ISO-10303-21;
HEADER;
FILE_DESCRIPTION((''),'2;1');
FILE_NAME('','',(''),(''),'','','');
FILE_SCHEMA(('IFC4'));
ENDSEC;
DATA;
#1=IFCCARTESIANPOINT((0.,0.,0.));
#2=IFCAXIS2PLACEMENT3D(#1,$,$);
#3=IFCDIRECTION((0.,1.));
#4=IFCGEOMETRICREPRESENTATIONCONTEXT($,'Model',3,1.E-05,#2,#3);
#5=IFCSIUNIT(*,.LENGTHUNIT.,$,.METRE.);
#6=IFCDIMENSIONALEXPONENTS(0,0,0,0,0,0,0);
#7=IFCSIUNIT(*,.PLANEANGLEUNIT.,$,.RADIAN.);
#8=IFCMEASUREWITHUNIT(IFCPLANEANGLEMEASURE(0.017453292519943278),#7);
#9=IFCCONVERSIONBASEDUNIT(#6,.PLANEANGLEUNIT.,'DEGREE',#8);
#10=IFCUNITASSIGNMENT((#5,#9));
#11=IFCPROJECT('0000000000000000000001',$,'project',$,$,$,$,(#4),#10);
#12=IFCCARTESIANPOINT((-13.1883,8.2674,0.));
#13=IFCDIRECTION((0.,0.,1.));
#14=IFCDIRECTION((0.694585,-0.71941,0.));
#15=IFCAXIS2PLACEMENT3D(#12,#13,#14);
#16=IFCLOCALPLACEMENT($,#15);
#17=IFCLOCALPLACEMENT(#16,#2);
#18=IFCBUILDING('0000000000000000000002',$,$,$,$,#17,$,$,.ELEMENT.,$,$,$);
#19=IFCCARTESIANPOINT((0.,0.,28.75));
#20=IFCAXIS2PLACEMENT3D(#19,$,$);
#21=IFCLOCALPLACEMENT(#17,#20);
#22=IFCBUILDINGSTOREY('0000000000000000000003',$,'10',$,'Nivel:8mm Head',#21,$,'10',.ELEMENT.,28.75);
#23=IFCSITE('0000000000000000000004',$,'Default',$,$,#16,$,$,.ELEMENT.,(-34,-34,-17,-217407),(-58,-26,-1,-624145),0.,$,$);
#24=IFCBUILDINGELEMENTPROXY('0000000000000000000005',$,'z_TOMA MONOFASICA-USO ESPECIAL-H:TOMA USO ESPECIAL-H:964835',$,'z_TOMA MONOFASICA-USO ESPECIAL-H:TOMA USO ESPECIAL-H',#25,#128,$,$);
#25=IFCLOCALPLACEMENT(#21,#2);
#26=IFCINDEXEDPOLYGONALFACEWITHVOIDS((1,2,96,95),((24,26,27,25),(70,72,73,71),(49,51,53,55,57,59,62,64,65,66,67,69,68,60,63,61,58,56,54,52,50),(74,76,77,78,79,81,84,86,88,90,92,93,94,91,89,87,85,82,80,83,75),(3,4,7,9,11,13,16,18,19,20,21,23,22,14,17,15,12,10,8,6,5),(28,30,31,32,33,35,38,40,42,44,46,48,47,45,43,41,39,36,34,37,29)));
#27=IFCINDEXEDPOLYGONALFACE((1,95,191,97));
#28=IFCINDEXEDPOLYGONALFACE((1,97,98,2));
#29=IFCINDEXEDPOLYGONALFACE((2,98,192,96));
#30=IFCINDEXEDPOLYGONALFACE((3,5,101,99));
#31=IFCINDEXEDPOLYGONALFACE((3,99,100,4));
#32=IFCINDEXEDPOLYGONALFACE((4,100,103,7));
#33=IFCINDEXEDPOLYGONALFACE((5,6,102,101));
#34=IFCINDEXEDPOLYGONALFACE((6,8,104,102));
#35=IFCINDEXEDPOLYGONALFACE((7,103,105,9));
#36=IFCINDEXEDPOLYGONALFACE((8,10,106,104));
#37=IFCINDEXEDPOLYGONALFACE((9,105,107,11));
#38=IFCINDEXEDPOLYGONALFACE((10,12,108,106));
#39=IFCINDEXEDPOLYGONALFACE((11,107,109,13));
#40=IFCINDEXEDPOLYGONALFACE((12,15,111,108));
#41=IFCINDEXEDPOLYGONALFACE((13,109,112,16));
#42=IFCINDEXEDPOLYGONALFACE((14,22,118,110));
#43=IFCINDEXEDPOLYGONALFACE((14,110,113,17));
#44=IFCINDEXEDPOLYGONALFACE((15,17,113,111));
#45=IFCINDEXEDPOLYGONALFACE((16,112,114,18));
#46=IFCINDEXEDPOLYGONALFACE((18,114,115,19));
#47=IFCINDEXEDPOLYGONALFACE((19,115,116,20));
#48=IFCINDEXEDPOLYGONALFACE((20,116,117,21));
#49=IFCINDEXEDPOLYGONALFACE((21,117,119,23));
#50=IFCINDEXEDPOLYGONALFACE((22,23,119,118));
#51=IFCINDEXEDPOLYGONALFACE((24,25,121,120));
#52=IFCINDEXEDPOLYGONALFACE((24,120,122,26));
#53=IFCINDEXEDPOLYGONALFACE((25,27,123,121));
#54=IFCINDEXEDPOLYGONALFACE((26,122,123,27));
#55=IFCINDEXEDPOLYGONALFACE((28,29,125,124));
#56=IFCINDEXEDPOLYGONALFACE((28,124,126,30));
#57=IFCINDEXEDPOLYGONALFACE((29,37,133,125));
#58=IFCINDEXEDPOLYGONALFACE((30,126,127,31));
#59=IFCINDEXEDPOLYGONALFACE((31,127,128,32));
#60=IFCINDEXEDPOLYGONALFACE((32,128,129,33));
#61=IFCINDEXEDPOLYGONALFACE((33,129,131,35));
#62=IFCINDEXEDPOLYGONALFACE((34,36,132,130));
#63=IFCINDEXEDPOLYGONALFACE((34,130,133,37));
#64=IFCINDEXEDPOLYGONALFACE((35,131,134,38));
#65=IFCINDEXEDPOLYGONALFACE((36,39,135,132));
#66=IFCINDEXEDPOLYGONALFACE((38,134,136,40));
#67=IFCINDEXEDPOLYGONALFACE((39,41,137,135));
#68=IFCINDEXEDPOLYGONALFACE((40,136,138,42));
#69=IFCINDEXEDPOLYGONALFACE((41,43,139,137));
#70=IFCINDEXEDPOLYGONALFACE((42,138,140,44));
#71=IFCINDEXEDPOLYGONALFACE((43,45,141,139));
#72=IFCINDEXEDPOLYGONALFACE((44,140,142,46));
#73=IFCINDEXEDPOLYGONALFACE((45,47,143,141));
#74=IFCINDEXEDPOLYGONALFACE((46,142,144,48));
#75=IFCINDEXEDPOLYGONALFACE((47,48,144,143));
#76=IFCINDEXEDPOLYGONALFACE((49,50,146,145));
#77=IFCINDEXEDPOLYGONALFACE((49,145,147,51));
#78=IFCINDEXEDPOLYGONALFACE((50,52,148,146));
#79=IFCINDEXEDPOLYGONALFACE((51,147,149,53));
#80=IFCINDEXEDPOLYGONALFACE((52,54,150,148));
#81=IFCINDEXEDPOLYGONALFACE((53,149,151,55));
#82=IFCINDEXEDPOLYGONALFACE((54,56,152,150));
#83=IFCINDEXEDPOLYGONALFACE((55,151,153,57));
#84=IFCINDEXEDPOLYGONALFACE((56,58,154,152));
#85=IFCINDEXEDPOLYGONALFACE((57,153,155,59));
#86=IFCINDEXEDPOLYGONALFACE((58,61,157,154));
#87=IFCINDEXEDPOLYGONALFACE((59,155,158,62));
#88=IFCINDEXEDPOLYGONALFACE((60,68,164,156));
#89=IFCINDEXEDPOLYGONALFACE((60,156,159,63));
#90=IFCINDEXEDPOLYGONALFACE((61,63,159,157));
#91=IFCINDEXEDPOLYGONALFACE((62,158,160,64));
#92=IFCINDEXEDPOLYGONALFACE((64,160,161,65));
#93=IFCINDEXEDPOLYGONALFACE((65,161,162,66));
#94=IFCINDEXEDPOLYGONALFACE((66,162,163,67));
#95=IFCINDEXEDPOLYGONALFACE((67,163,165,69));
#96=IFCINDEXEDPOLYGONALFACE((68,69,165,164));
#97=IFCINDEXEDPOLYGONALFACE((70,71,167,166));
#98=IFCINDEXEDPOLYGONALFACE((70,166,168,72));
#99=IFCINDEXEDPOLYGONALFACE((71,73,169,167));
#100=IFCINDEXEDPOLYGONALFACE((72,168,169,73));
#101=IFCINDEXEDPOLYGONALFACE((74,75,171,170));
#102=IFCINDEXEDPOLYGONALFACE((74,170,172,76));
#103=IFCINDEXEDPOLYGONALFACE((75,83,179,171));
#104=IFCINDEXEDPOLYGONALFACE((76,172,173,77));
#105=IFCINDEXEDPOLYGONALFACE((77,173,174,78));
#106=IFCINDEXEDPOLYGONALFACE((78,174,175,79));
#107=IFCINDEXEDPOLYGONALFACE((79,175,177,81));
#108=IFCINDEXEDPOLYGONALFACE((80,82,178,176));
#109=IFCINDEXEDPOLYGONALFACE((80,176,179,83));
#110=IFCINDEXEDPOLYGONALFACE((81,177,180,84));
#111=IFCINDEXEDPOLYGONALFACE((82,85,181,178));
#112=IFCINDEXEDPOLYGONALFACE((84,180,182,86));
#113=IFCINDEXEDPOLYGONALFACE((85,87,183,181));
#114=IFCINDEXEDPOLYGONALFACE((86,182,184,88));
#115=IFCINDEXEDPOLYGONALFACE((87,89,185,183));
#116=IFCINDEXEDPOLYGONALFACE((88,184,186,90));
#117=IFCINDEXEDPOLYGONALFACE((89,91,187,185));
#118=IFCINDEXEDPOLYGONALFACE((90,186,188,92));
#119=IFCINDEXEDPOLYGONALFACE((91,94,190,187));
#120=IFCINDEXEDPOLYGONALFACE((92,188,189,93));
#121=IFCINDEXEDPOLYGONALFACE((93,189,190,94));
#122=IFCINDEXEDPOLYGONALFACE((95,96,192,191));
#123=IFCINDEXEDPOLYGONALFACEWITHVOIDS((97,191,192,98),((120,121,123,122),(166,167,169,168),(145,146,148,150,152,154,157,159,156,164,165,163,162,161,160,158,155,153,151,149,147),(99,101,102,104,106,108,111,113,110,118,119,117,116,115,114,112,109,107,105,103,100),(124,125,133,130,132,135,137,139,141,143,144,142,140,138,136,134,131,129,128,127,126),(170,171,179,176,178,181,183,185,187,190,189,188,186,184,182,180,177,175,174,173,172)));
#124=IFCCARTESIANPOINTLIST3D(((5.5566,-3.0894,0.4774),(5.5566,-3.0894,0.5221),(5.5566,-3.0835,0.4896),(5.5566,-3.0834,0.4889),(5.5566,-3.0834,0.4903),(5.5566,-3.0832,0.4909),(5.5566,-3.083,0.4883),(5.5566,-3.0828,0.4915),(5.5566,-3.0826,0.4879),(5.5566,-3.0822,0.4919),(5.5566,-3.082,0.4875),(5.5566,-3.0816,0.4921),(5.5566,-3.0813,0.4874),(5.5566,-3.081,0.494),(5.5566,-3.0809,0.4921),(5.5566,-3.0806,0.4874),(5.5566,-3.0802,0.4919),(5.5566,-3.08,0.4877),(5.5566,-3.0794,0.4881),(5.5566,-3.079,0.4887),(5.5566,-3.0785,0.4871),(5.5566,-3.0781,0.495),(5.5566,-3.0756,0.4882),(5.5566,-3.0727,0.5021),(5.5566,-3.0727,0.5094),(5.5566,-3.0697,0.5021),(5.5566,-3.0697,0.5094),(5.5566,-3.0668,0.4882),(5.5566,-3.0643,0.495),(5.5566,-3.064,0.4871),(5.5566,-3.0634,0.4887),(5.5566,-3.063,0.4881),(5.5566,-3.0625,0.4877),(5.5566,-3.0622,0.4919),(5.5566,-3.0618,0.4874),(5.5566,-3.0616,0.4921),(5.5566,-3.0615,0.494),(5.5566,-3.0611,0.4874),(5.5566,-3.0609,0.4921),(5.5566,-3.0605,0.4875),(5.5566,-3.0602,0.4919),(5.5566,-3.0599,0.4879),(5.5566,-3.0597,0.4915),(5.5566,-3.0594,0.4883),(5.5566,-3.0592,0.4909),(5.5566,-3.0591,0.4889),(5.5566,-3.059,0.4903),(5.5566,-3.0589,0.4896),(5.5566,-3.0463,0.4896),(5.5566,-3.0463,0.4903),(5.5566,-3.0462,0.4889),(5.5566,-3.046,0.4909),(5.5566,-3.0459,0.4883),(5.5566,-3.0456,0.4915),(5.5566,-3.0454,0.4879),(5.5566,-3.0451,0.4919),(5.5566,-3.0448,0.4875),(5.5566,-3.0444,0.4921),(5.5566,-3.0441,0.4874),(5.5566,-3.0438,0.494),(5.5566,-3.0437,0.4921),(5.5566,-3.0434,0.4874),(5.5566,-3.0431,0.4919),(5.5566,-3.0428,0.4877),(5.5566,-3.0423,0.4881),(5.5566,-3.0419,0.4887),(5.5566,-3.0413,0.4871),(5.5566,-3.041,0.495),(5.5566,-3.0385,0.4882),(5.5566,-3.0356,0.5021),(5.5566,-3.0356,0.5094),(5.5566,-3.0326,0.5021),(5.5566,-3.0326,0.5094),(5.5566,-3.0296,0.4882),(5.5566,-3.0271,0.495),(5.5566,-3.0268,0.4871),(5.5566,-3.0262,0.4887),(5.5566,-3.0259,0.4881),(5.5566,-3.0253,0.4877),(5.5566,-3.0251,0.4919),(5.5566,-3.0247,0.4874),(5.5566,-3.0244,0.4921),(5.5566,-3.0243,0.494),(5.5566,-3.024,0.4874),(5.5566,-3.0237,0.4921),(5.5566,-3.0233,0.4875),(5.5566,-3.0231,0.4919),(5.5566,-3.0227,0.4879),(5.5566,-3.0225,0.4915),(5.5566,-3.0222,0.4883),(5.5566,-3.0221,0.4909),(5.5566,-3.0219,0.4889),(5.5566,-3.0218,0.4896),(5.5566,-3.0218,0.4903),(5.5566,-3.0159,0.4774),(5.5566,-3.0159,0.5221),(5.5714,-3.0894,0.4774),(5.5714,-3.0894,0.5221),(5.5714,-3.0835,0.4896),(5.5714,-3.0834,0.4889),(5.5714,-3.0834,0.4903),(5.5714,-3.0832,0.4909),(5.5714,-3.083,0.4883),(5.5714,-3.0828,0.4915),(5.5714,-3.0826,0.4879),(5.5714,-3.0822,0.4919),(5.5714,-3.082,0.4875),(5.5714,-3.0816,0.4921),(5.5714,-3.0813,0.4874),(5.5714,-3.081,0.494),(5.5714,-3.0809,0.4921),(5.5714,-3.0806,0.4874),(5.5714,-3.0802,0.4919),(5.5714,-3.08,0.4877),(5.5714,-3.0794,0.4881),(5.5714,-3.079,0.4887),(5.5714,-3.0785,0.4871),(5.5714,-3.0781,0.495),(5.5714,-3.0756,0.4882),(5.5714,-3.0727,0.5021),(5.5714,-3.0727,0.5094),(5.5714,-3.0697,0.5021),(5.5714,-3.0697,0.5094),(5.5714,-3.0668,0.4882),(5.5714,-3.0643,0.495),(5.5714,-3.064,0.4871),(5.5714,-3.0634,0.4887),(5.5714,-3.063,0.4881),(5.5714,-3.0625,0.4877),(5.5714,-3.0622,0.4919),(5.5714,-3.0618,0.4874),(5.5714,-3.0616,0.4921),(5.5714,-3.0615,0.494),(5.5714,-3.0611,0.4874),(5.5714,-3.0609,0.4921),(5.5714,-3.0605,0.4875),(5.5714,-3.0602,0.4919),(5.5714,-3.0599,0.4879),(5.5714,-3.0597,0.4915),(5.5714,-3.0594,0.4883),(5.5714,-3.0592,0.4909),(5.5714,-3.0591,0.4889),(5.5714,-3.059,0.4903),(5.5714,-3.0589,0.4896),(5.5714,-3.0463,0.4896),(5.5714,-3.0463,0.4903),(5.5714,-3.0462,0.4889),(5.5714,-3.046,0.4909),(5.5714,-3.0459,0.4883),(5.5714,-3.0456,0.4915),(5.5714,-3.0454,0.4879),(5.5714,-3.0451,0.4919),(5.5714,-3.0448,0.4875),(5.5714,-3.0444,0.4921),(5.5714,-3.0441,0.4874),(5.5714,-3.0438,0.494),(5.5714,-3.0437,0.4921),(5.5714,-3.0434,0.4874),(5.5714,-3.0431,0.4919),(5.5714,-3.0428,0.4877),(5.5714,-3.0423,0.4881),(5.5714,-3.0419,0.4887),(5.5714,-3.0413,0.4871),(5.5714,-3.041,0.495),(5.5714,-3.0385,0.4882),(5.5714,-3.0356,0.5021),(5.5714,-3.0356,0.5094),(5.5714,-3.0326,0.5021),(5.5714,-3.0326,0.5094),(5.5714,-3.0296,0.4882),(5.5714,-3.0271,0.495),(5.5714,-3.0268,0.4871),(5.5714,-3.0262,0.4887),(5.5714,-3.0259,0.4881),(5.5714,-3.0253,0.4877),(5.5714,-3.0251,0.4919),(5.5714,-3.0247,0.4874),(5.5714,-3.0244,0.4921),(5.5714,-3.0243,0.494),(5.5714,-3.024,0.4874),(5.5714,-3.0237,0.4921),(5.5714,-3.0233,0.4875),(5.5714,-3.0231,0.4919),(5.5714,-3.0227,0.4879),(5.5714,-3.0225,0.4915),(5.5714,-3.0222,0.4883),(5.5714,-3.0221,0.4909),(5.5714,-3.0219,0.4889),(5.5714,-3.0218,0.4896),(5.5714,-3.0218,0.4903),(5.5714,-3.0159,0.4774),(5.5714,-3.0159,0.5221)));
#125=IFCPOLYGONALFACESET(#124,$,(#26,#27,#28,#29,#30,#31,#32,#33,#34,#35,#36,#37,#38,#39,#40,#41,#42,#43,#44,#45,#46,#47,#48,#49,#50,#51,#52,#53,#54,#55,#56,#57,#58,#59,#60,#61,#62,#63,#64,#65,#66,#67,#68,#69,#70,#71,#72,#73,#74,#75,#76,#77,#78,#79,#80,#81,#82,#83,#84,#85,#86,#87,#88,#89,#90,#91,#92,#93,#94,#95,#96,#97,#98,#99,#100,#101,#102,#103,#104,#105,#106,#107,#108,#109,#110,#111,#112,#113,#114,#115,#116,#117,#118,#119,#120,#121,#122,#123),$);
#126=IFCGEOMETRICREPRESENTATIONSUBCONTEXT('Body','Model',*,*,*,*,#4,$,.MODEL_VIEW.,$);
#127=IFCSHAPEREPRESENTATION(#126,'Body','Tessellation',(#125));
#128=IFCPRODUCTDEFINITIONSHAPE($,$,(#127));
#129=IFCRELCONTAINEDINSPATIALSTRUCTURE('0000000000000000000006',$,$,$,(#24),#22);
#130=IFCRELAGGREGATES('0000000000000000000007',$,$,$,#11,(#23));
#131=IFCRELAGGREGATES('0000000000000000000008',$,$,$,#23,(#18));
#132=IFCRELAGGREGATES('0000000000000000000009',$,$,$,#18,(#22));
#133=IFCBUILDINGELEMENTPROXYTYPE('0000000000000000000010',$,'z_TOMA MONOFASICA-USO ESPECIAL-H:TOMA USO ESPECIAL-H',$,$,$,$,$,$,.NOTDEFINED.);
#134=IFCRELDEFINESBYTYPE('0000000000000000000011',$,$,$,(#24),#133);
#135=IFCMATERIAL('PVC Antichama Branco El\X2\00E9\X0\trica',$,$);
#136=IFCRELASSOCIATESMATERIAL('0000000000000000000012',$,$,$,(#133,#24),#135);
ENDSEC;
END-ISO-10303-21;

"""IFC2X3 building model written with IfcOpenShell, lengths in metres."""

from ifc_helpers import new_model, entity, si_unit, converted_unit, direction, frame, frame_2d, origin, place, context, subcontext, project, spatial, polyline, circle_curve, parameter, trimmed, segment, composite_curve, outline, extrude, source, transform, mapped, material, type_object, type_shapes, element, save


model = new_model("IFC2X3")

# Units and contexts
model_context = context("Model", 3, precision=1e-05, world=origin(), true_north=direction((0.0, 1.0)))
body_context = subcontext(model_context, "Body", "Model", "MODEL_VIEW")
ifc_project = project(units=[si_unit("LENGTHUNIT", "METRE"), converted_unit("PLANEANGLEUNIT", "DEGREE", entity("IfcPlaneAngleMeasure", 0.017453292519943278), si_unit("PLANEANGLEUNIT", "RADIAN"), dimensions=[0, 0, 0, 0, 0, 0, 0])], contexts=[model_context])

# Site, building, storey
site_placement = place(None, frame((-13.1883, 8.2674, 0.0), z_axis=(0.0, 0.0, 1.0), x_axis=(0.694585, -0.71941, 0.0)))
site = spatial("IfcSite", under=ifc_project, at=site_placement, Name="Default", CompositionType="ELEMENT", RefLatitude=(-34, -34, -17, -217407), RefLongitude=(-58, -26, -1, -624145), RefElevation=0.0)
building_placement = place(site_placement, origin())
building = spatial("IfcBuilding", under=site, at=building_placement, CompositionType="ELEMENT")
storey_placement = place(building_placement, frame((0.0, 0.0, 28.75)))
storey = spatial("IfcBuildingStorey", under=building, at=storey_placement, Name="10", ObjectType="Nivel:8mm Head", LongName="10", CompositionType="ELEMENT", Elevation=28.75)

# Building element proxy
ifc_material_1 = material(Name="PVC Antichama Branco Elétrica")
building_element_proxy_type_1 = type_object("IfcBuildingElementProxyType", Name="z_TOMA MONOFASICA-USO ESPECIAL-H:TOMA USO ESPECIAL-H", PredefinedType="NOTDEFINED", material=ifc_material_1)
shared_shape_1 = source(origin(), body_context, "Body", "SweptSolid", [
    extrude(outline(polyline([(-0.0368, -0.0223), (0.0368, -0.0223), (0.0368, 0.0223), (-0.0368, 0.0223), (-0.0368, -0.0223)]), holes=[composite_curve([segment(polyline([(0.0141, 0.0115), (0.0116, 0.0047)]), True, "CONTINUOUS"), segment(polyline([(0.0116, 0.0047), (0.0088, 0.0057)]), True, "CONTINUOUS"), segment(polyline([(0.0088, 0.0057), (0.0096, 0.0078)]), True, "CONTINUOUS"), segment(trimmed(circle_curve(frame_2d((0.0087, 0.0099), x_axis=(1.0, 0.0)), 0.0024), [parameter(27.118901)], [parameter(292.881099)], True, "PARAMETER"), False, "CONTINUOUS"), segment(polyline([(0.0108, 0.011), (0.0113, 0.0126)]), True, "CONTINUOUS"), segment(polyline([(0.0113, 0.0126), (0.0141, 0.0115)]), True, "CONTINUOUS")], self_intersect=False), composite_curve([segment(polyline([(0.0255, 0.0047), (0.023, 0.0115)]), True, "CONTINUOUS"), segment(polyline([(0.023, 0.0115), (0.0258, 0.0126)]), True, "CONTINUOUS"), segment(polyline([(0.0258, 0.0126), (0.0264, 0.011)]), True, "CONTINUOUS"), segment(trimmed(circle_curve(frame_2d((0.0285, 0.0099), x_axis=(1.0, 0.0)), 0.0024), [parameter(247.118901)], [parameter(152.881099)], True, "PARAMETER"), False, "CONTINUOUS"), segment(polyline([(0.0276, 0.0078), (0.0283, 0.0057)]), True, "CONTINUOUS"), segment(polyline([(0.0283, 0.0057), (0.0255, 0.0047)]), True, "CONTINUOUS")], self_intersect=False), polyline([(0.0201, -0.0024), (0.0201, -0.0097), (0.0171, -0.0097), (0.0171, -0.0024), (0.0201, -0.0024)]), composite_curve([segment(polyline([(-0.0141, 0.0115), (-0.0113, 0.0126)]), True, "CONTINUOUS"), segment(polyline([(-0.0113, 0.0126), (-0.0108, 0.011)]), True, "CONTINUOUS"), segment(trimmed(circle_curve(frame_2d((-0.0087, 0.0099), x_axis=(1.0, 0.0)), 0.0024), [parameter(247.118901)], [parameter(152.881099)], True, "PARAMETER"), False, "CONTINUOUS"), segment(polyline([(-0.0096, 0.0078), (-0.0088, 0.0057)]), True, "CONTINUOUS"), segment(polyline([(-0.0088, 0.0057), (-0.0116, 0.0047)]), True, "CONTINUOUS"), segment(polyline([(-0.0116, 0.0047), (-0.0141, 0.0115)]), True, "CONTINUOUS")], self_intersect=False), composite_curve([segment(polyline([(-0.0255, 0.0047), (-0.0283, 0.0057)]), True, "CONTINUOUS"), segment(polyline([(-0.0283, 0.0057), (-0.0276, 0.0078)]), True, "CONTINUOUS"), segment(trimmed(circle_curve(frame_2d((-0.0285, 0.0099), x_axis=(1.0, 0.0)), 0.0024), [parameter(27.118901)], [parameter(292.881099)], True, "PARAMETER"), False, "CONTINUOUS"), segment(polyline([(-0.0264, 0.011), (-0.0258, 0.0126)]), True, "CONTINUOUS"), segment(polyline([(-0.0258, 0.0126), (-0.023, 0.0115)]), True, "CONTINUOUS"), segment(polyline([(-0.023, 0.0115), (-0.0255, 0.0047)]), True, "CONTINUOUS")], self_intersect=False), polyline([(-0.0201, -0.0024), (-0.0171, -0.0024), (-0.0171, -0.0097), (-0.0201, -0.0097), (-0.0201, -0.0024)])]), frame((0.0, -0.005, 0.0223), z_axis=(0.0, 1.0, 0.0), x_axis=(1.0, 0.0, 0.0)), (0.0, 0.0, 1.0), 0.0148),
])
type_shapes(building_element_proxy_type_1, [shared_shape_1])
for number, where, z_axis, x_axis, name in (
    (1, (5.5664, -3.0526, 0.4774), (0.0, 0.0, 1.0), (0.0, 1.0, 0.0), "z_TOMA MONOFASICA-USO ESPECIAL-H:TOMA USO ESPECIAL-H:964835"),
):
    element("IfcBuildingElementProxy", number, at=place(storey_placement, frame(where, z_axis=z_axis, x_axis=x_axis)), inside=storey, type_object=building_element_proxy_type_1, material=ifc_material_1, Name=name, ObjectType="z_TOMA MONOFASICA-USO ESPECIAL-H:TOMA USO ESPECIAL-H", context=body_context, shape_type="MappedRepresentation", body=[
        mapped(shared_shape_1, transform((0.0, 0.0, 0.0), scale=1.0)),
    ])

save(model, "model.ifc")
